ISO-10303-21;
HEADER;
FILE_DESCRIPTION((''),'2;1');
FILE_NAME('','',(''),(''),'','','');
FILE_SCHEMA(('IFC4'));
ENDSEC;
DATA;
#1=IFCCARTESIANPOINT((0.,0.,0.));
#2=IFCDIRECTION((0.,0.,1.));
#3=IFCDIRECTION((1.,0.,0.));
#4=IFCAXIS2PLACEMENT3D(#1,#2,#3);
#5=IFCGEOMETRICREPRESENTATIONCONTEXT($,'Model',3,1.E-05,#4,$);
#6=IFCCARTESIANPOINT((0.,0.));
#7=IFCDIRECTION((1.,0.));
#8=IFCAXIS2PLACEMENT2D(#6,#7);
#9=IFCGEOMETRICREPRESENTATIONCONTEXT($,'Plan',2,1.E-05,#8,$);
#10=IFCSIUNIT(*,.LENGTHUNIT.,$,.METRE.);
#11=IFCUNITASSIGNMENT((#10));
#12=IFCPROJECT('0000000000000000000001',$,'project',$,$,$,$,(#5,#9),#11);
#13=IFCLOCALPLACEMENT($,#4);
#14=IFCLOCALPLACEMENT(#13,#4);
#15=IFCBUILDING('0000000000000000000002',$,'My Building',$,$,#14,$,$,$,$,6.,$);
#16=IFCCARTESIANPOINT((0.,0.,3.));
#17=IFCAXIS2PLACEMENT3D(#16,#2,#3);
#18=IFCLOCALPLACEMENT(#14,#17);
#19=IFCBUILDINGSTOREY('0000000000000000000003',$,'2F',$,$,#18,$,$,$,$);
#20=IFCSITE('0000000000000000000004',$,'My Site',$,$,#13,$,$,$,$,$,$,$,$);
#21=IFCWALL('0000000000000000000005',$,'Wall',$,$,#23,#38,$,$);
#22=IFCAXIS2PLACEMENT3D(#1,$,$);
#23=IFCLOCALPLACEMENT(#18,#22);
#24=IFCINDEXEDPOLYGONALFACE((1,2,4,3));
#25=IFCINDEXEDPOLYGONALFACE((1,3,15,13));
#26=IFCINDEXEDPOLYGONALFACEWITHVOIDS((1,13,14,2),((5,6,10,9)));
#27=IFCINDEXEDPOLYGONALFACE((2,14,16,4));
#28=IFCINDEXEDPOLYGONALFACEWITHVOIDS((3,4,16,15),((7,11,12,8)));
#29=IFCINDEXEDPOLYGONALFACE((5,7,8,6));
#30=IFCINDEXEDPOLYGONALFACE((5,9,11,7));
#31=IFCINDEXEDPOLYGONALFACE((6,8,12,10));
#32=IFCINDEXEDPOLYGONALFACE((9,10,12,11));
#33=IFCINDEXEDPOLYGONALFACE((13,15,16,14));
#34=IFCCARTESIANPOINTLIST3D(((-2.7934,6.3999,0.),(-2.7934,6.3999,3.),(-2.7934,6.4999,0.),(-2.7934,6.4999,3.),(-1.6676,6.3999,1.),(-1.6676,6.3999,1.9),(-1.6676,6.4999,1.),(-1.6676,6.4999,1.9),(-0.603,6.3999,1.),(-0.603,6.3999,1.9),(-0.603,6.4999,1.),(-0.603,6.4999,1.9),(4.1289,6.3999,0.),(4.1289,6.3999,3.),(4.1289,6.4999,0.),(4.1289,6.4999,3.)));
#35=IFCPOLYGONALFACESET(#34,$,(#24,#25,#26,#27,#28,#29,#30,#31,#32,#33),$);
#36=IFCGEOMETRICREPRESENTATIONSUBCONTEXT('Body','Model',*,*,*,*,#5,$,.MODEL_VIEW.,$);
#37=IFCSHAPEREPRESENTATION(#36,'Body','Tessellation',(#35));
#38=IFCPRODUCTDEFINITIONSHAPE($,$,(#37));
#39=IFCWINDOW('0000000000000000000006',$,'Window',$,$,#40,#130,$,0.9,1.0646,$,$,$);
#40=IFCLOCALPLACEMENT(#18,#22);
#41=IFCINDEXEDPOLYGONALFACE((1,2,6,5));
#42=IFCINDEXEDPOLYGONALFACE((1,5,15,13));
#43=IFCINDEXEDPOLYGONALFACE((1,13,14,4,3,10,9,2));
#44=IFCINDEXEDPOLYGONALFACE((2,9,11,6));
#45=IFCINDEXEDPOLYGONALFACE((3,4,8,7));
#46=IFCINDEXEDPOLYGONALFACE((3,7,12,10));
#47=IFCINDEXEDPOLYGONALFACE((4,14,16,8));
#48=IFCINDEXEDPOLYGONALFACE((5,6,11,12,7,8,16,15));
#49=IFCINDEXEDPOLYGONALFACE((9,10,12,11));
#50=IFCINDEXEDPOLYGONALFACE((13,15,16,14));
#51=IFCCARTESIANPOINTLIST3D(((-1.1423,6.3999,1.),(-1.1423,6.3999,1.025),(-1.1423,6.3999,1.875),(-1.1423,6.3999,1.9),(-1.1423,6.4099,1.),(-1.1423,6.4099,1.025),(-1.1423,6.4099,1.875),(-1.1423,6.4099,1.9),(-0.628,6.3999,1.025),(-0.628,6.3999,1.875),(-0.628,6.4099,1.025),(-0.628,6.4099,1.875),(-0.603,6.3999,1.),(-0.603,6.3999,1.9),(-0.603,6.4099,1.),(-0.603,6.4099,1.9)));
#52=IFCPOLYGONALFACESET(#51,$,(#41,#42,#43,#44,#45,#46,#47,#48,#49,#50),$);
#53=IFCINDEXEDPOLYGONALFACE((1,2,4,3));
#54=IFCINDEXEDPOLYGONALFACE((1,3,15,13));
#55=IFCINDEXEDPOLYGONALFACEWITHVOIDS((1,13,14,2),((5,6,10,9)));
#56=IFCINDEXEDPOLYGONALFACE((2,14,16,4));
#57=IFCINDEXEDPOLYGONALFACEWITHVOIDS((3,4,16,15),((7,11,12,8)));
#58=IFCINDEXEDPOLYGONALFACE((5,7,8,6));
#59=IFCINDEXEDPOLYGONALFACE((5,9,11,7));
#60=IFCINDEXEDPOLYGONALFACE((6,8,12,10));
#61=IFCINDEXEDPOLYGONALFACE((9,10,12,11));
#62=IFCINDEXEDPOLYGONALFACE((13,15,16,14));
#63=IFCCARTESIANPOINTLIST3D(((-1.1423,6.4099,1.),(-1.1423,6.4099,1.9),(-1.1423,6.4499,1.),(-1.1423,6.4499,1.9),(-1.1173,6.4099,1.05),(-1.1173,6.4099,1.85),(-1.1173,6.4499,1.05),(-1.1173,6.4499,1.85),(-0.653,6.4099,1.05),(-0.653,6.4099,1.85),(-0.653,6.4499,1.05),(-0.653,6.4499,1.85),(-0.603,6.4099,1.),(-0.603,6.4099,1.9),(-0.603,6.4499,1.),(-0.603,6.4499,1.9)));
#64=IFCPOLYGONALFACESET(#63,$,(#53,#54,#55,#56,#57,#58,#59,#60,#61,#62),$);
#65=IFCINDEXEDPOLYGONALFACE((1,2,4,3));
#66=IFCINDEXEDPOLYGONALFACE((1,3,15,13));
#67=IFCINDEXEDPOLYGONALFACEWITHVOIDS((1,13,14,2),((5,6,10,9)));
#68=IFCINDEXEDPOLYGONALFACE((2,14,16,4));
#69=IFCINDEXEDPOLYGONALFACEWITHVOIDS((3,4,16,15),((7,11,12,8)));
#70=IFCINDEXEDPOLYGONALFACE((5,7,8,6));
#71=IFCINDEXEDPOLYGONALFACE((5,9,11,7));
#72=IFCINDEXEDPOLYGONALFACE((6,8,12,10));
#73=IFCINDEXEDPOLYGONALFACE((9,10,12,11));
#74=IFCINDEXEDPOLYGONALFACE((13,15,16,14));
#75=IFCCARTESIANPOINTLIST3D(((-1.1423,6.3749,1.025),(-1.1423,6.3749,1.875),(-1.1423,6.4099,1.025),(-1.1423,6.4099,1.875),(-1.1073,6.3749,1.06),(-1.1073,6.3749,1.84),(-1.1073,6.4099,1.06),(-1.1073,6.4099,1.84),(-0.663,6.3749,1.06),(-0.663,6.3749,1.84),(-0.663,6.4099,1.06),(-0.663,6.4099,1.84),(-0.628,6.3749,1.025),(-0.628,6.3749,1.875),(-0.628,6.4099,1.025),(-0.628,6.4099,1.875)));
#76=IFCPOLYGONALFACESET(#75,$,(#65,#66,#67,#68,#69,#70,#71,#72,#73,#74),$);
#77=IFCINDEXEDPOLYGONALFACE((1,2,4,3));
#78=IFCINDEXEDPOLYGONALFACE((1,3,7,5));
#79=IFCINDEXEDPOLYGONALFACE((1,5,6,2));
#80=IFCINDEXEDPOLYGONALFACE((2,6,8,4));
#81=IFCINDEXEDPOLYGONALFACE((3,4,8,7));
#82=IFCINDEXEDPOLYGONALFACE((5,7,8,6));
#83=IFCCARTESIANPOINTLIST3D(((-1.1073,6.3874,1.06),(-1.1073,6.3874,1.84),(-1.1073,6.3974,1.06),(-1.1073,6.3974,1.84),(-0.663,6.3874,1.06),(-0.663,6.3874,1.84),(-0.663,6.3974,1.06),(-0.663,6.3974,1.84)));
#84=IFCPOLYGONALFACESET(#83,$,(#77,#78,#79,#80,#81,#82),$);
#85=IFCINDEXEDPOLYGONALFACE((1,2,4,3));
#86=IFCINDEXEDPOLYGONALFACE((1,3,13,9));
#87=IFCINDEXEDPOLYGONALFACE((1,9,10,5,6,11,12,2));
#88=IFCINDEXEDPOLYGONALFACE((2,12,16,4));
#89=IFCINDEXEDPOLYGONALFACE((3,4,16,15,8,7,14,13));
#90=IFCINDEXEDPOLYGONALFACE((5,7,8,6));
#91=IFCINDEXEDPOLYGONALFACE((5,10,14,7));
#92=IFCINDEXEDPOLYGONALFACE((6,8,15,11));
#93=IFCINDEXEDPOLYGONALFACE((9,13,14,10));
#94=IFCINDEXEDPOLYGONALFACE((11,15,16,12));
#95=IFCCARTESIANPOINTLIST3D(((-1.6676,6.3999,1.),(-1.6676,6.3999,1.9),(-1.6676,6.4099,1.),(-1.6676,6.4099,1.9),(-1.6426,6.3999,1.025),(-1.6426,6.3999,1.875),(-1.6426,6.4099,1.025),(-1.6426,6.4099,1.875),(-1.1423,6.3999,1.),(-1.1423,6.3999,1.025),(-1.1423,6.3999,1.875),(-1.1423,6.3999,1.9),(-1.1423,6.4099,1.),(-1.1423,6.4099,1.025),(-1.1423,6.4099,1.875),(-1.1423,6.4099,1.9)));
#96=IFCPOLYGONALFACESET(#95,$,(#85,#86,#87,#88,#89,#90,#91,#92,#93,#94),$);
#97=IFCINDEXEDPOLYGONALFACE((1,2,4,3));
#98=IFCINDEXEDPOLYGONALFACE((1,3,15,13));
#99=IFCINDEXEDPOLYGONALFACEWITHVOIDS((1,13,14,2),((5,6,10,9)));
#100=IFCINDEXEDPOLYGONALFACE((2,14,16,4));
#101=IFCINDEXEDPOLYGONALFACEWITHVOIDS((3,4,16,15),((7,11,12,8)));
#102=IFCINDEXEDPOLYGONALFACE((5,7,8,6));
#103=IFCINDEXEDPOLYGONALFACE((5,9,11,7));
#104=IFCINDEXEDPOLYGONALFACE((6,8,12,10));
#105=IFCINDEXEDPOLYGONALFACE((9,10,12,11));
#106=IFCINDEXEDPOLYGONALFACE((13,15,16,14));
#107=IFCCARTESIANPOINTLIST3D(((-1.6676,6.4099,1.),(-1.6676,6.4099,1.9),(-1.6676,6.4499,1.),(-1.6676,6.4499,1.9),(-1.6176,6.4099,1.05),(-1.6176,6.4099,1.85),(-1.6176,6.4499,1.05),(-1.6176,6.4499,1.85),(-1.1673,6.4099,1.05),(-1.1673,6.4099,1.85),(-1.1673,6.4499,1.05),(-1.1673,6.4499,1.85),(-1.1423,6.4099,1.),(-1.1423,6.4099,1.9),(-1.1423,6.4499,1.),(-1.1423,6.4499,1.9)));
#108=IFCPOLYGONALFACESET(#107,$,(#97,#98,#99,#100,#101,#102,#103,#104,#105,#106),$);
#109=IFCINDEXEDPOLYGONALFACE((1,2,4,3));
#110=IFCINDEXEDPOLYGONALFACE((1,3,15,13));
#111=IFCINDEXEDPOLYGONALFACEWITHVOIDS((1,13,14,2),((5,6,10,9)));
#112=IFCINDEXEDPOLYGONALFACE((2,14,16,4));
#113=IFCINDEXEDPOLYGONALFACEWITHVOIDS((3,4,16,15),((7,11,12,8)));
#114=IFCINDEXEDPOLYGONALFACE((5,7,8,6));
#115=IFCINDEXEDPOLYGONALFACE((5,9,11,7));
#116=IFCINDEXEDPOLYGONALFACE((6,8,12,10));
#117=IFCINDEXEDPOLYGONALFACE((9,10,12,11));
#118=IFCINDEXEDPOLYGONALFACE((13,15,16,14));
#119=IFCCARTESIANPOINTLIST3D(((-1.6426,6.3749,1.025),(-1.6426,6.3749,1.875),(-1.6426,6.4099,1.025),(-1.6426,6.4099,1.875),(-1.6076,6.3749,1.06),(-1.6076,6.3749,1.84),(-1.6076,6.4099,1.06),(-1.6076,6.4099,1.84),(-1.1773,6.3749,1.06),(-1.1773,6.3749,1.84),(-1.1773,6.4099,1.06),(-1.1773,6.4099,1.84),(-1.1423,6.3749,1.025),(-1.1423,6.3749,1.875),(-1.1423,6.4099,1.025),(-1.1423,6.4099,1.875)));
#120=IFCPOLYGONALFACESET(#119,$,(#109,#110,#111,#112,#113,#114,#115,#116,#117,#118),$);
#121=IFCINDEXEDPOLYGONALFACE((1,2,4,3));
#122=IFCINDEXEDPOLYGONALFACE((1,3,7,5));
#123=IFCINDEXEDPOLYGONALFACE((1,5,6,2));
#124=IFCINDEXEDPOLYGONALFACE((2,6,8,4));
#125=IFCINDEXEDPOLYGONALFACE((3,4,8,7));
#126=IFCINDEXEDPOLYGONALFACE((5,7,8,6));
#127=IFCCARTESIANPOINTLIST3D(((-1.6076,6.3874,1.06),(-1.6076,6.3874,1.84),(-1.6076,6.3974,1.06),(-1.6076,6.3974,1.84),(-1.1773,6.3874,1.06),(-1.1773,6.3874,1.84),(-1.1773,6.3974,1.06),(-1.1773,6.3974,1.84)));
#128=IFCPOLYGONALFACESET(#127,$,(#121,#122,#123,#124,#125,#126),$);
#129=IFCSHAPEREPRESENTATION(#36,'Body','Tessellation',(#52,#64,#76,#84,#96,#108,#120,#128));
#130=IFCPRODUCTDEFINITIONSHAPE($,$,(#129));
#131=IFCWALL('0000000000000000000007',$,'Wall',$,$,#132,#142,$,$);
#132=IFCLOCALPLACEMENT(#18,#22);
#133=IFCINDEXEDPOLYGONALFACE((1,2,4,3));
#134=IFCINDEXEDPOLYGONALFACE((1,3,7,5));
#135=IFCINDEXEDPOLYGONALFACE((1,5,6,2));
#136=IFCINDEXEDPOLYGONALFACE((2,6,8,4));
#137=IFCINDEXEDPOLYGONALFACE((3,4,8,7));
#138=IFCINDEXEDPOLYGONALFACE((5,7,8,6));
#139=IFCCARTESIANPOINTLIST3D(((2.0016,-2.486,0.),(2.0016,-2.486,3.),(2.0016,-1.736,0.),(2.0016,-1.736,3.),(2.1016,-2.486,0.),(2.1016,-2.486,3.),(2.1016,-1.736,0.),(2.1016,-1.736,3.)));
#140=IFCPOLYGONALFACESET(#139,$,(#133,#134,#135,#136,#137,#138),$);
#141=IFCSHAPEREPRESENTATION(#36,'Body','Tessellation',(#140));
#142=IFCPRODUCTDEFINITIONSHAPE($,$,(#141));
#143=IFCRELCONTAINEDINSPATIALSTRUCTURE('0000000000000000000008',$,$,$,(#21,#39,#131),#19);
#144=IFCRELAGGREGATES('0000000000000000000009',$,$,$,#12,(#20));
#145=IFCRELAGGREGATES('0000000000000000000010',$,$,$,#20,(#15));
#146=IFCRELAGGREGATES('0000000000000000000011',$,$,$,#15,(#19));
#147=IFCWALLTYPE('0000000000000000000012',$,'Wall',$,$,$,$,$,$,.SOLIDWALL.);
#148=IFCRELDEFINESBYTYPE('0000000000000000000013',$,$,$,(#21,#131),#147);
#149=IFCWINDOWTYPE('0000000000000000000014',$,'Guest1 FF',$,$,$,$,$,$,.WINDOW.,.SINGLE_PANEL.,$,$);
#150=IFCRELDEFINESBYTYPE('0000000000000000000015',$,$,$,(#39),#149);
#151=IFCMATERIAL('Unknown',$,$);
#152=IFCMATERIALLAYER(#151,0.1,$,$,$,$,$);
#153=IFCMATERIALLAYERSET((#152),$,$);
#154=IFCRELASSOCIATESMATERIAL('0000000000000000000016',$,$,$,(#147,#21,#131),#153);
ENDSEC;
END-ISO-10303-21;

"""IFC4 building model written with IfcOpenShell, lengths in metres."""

from ifc_helpers import new_model, entity, si_unit, frame, origin_with_axes, origin_2d_with_axis, place, context, subcontext, project, spatial, line, indexed_curve, outline, extrude, shape, source, transform, mapped, material, layer, layer_set, layer_usage, type_object, type_shapes, element, fill, save


model = new_model("IFC4")

# Units and contexts
model_context = context("Model", 3, precision=1e-05, world=origin_with_axes())
plan_context = context("Plan", 2, precision=1e-05, world=origin_2d_with_axis())
body_context_1 = subcontext(model_context, "Body", "Model", "MODEL_VIEW")
body_context_2 = subcontext(plan_context, "Body", "Plan", "PLAN_VIEW")
ifc_project = project(units=[si_unit("LENGTHUNIT", "METRE")], contexts=[model_context, plan_context])

# Site, building, storey
site_placement = place(None, origin_with_axes())
site = spatial("IfcSite", under=ifc_project, at=site_placement, Name="My Site")
building_placement = place(site_placement, origin_with_axes())
building = spatial("IfcBuilding", under=site, at=building_placement, Name="My Building", ElevationOfTerrain=6.0)
storey_placement = place(building_placement, frame((0.0, 0.0, 3.0), z_axis=(0.0, 0.0, 1.0), x_axis=(1.0, 0.0, 0.0)))
storey = spatial("IfcBuildingStorey", under=building, at=storey_placement, Name="2F")

# Shared definitions
ifc_material = material(Name="Unknown")

# Shared definitions
ifc_layer_1 = layer(ifc_material, 0.1)
ifc_layer_set_1 = layer_set([ifc_layer_1])
wall_type = type_object("IfcWallType", Name="Wall", PredefinedType="SOLIDWALL", material=ifc_layer_set_1)
shared_shape_1 = source(origin_with_axes(), body_context_1, "Body", "SweptSolid", [
    extrude(outline(indexed_curve([(0.0, 0.0), (1.0646, 0.0), (1.0646, 0.9), (0.0, 0.9)], segments=[line(1, 2, 3, 4, 1)])), frame((0.0, -0.6, 0.0), z_axis=(0.0, -1.0, 0.0), x_axis=(1.0, 0.0, 0.0)), (0.0, 0.0, -1.0), 1.2),
])
window_type_1 = type_object("IfcWindowType", Name="Guest1 FF", PartitioningType="SINGLE_PANEL", PredefinedType="WINDOW")
shared_shape_2 = source(origin_with_axes(), body_context_1, "Body", "SweptSolid", [
    extrude(outline(indexed_curve([(0.5393, 0.0), (0.0, 0.0), (0.0, 0.9), (0.5393, 0.9), (0.5393, 0.875), (0.025, 0.875), (0.025, 0.025), (0.5393, 0.025)], segments=[line(1, 2, 3, 4, 5, 6, 7, 8, 1)])), frame((0.0, 0.09, 0.0), z_axis=(0.0, -1.0, 0.0), x_axis=(1.0, 0.0, 0.0)), (0.0, 0.0, -1.0), 0.01),
    extrude(outline(indexed_curve([(0.0, 0.0), (0.5393, 0.0), (0.5393, 0.9), (0.0, 0.9)], segments=[line(1, 2, 3, 4, 1)]), holes=[indexed_curve([(0.05, 0.05), (0.5143, 0.05), (0.5143, 0.85), (0.05, 0.85)], segments=[line(1, 2, 3, 4, 1)])]), frame((0.0, 0.05, 0.0), z_axis=(0.0, -1.0, 0.0), x_axis=(1.0, 0.0, 0.0)), (0.0, 0.0, -1.0), 0.04),
    extrude(outline(indexed_curve([(0.0, 0.0), (0.5143, 0.0), (0.5143, 0.85), (0.0, 0.85)], segments=[line(1, 2, 3, 4, 1)]), holes=[indexed_curve([(0.035, 0.035), (0.4793, 0.035), (0.4793, 0.815), (0.035, 0.815)], segments=[line(1, 2, 3, 4, 1)])]), frame((0.025, 0.09, 0.025), z_axis=(0.0, -1.0, 0.0), x_axis=(1.0, 0.0, 0.0)), (0.0, 0.0, -1.0), 0.035),
    extrude(outline(indexed_curve([(0.035, 0.035), (0.4793, 0.035), (0.4793, 0.815), (0.035, 0.815)], segments=[line(1, 2, 3, 4, 1)])), frame((0.025, 0.1025, 0.025), z_axis=(0.0, -1.0, 0.0), x_axis=(1.0, 0.0, 0.0)), (0.0, 0.0, -1.0), 0.01),
    extrude(outline(indexed_curve([(0.0, 0.9), (0.5253, 0.9), (0.5253, 0.0), (0.0, 0.0), (0.0, 0.025), (0.5003, 0.025), (0.5003, 0.875), (0.0, 0.875)], segments=[line(1, 2, 3, 4, 5, 6, 7, 8, 1)])), frame((0.5393, 0.09, 0.0), z_axis=(0.0, -1.0, 0.0), x_axis=(1.0, 0.0, 0.0)), (0.0, 0.0, -1.0), 0.01),
    extrude(outline(indexed_curve([(0.0, 0.0), (0.5253, 0.0), (0.5253, 0.9), (0.0, 0.9)], segments=[line(1, 2, 3, 4, 1)]), holes=[indexed_curve([(0.025, 0.05), (0.4753, 0.05), (0.4753, 0.85), (0.025, 0.85)], segments=[line(1, 2, 3, 4, 1)])]), frame((0.5393, 0.05, 0.0), z_axis=(0.0, -1.0, 0.0), x_axis=(1.0, 0.0, 0.0)), (0.0, 0.0, -1.0), 0.04),
    extrude(outline(indexed_curve([(0.0, 0.0), (0.5003, 0.0), (0.5003, 0.85), (0.0, 0.85)], segments=[line(1, 2, 3, 4, 1)]), holes=[indexed_curve([(0.035, 0.035), (0.4653, 0.035), (0.4653, 0.815), (0.035, 0.815)], segments=[line(1, 2, 3, 4, 1)])]), frame((0.5393, 0.09, 0.025), z_axis=(0.0, -1.0, 0.0), x_axis=(1.0, 0.0, 0.0)), (0.0, 0.0, -1.0), 0.035),
    extrude(outline(indexed_curve([(0.035, 0.035), (0.4653, 0.035), (0.4653, 0.815), (0.035, 0.815)], segments=[line(1, 2, 3, 4, 1)])), frame((0.5393, 0.1025, 0.025), z_axis=(0.0, -1.0, 0.0), x_axis=(1.0, 0.0, 0.0)), (0.0, 0.0, -1.0), 0.01),
])
shared_shape_3 = source(origin_with_axes(), body_context_2, "Body", "Curve2D", [
    entity("IfcIndexedPolyCurve", entity("IfcCartesianPointList2D", [[0.05, 0.05], [0.5143, 0.05]])),
    entity("IfcIndexedPolyCurve", entity("IfcCartesianPointList2D", [[0.0, 0.1], [0.025, 0.1], [0.025, 0.09], [0.05, 0.09], [0.05, 0.05], [0.0, 0.05]]), [entity("IfcLineIndex", [1, 2, 3, 4, 5, 6, 1])]),
    entity("IfcIndexedPolyCurve", entity("IfcCartesianPointList2D", [[0.5393, 0.1], [0.5393, 0.1], [0.5393, 0.09], [0.5143, 0.09], [0.5143, 0.05], [0.5393, 0.05]])),
    entity("IfcIndexedPolyCurve", entity("IfcCartesianPointList2D", [[0.025, 0.09], [0.06, 0.09], [0.06, 0.125], [0.025, 0.125]]), [entity("IfcLineIndex", [1, 2, 3, 4, 1])]),
    entity("IfcIndexedPolyCurve", entity("IfcCartesianPointList2D", [[0.5393, 0.09], [0.5043, 0.09], [0.5043, 0.125], [0.5393, 0.125]]), [entity("IfcLineIndex", [1, 2, 3, 4, 1])]),
    entity("IfcIndexedPolyCurve", entity("IfcCartesianPointList2D", [[0.06, 0.09], [0.5043, 0.09]])),
    entity("IfcIndexedPolyCurve", entity("IfcCartesianPointList2D", [[0.06, 0.125], [0.5043, 0.125]])),
    entity("IfcIndexedPolyCurve", entity("IfcCartesianPointList2D", [[0.06, 0.1075], [0.5043, 0.1075]])),
    entity("IfcIndexedPolyCurve", entity("IfcCartesianPointList2D", [[0.5643, 0.05], [1.0146, 0.05]])),
    entity("IfcIndexedPolyCurve", entity("IfcCartesianPointList2D", [[0.5393, 0.1], [0.5393, 0.1], [0.5393, 0.09], [0.5643, 0.09], [0.5643, 0.05], [0.5393, 0.05]])),
    entity("IfcIndexedPolyCurve", entity("IfcCartesianPointList2D", [[1.0646, 0.1], [1.0396, 0.1], [1.0396, 0.09], [1.0146, 0.09], [1.0146, 0.05], [1.0646, 0.05]]), [entity("IfcLineIndex", [1, 2, 3, 4, 5, 6, 1])]),
    entity("IfcIndexedPolyCurve", entity("IfcCartesianPointList2D", [[0.5393, 0.09], [0.5743, 0.09], [0.5743, 0.125], [0.5393, 0.125]]), [entity("IfcLineIndex", [1, 2, 3, 4, 1])]),
    entity("IfcIndexedPolyCurve", entity("IfcCartesianPointList2D", [[1.0396, 0.09], [1.0046, 0.09], [1.0046, 0.125], [1.0396, 0.125]]), [entity("IfcLineIndex", [1, 2, 3, 4, 1])]),
    entity("IfcIndexedPolyCurve", entity("IfcCartesianPointList2D", [[0.5743, 0.09], [1.0046, 0.09]])),
    entity("IfcIndexedPolyCurve", entity("IfcCartesianPointList2D", [[0.5743, 0.125], [1.0046, 0.125]])),
    entity("IfcIndexedPolyCurve", entity("IfcCartesianPointList2D", [[0.5743, 0.1075], [1.0046, 0.1075]])),
])
type_shapes(window_type_1, [shared_shape_2, shared_shape_3])

# Wall, opening, window
ifc_layer_usage_1 = layer_usage(ifc_layer_set_1, "AXIS2", "POSITIVE", 0.0)
wall_1_placement = place(storey_placement, frame((4.1289, 6.4999, 0.0), z_axis=(0.0, 0.0, 1.0), x_axis=(-1.0, 0.0, 0.0)))
wall_1 = element("IfcWall", 1, at=wall_1_placement, inside=storey, type_object=wall_type, material=ifc_layer_usage_1, Name="Wall", context=body_context_1, shape_type="SweptSolid", body=[
    extrude(outline(indexed_curve([(0.0, 0.0), (0.0, 0.1), (6.9223, 0.1), (6.9223, 0.0)], segments=[line(1, 2, 3, 4, 1)])), origin_with_axes(), (0.0, 0.0, 1.0), 3.0),
])
opening_1_placement = place(wall_1_placement, frame((4.7319, 0.0, 1.0), z_axis=(0.0, 0.0, 1.0), x_axis=(1.0, 0.0, 0.0)))
opening_1 = element("IfcOpeningElement", 2, at=opening_1_placement, cuts=wall_1, PredefinedType="OPENING", context=body_context_1, shape_type="MappedRepresentation", body=[
    mapped(shared_shape_1, transform((0.0, 0.0, 0.0), x_axis=(1.0, 0.0, 0.0), y_axis=(0.0, 1.0, 0.0), z_axis=(0.0, 0.0, 1.0), scale=1.0)),
])
window_1_placement = place(opening_1_placement, frame((0.0, 0.0, 0.0), z_axis=(0.0, 0.0, 1.0), x_axis=(1.0, 0.0, 0.0)))
window_1 = element("IfcWindow", 3, at=window_1_placement, inside=storey, type_object=window_type_1, Name="Window", OverallHeight=0.9, OverallWidth=1.0646, shapes=[
    shape(body_context_1, "Body", "MappedRepresentation", [mapped(shared_shape_2, transform((0.0, 0.0, 0.0), x_axis=(1.0, 0.0, 0.0), y_axis=(0.0, 1.0, 0.0), z_axis=(0.0, 0.0, 1.0), scale=1.0))]),
    shape(body_context_2, "Body", "MappedRepresentation", [mapped(shared_shape_3, transform((0.0, 0.0, 0.0), x_axis=(1.0, 0.0, 0.0), y_axis=(0.0, 1.0, 0.0), z_axis=(0.0, 0.0, 1.0), scale=1.0))]),
])
fill(opening_1, window_1)

# Wall
ifc_layer_usage_2 = layer_usage(ifc_layer_set_1, "AXIS2", "POSITIVE", 0.0)
wall_2_placement = place(storey_placement, frame((2.1016, -2.486, 0.0), z_axis=(0.0, 0.0, 1.0), x_axis=(0.0, 1.0, 0.0)))
element("IfcWall", 4, at=wall_2_placement, inside=storey, type_object=wall_type, material=ifc_layer_usage_2, Name="Wall", context=body_context_1, shape_type="SweptSolid", body=[
    extrude(outline(indexed_curve([(0.0, 0.0), (0.0, 0.1), (0.75, 0.1), (0.75, 0.0)], segments=[line(1, 2, 3, 4, 1)])), origin_with_axes(), (0.0, 0.0, 1.0), 3.0),
])

save(model, "model.ifc")
